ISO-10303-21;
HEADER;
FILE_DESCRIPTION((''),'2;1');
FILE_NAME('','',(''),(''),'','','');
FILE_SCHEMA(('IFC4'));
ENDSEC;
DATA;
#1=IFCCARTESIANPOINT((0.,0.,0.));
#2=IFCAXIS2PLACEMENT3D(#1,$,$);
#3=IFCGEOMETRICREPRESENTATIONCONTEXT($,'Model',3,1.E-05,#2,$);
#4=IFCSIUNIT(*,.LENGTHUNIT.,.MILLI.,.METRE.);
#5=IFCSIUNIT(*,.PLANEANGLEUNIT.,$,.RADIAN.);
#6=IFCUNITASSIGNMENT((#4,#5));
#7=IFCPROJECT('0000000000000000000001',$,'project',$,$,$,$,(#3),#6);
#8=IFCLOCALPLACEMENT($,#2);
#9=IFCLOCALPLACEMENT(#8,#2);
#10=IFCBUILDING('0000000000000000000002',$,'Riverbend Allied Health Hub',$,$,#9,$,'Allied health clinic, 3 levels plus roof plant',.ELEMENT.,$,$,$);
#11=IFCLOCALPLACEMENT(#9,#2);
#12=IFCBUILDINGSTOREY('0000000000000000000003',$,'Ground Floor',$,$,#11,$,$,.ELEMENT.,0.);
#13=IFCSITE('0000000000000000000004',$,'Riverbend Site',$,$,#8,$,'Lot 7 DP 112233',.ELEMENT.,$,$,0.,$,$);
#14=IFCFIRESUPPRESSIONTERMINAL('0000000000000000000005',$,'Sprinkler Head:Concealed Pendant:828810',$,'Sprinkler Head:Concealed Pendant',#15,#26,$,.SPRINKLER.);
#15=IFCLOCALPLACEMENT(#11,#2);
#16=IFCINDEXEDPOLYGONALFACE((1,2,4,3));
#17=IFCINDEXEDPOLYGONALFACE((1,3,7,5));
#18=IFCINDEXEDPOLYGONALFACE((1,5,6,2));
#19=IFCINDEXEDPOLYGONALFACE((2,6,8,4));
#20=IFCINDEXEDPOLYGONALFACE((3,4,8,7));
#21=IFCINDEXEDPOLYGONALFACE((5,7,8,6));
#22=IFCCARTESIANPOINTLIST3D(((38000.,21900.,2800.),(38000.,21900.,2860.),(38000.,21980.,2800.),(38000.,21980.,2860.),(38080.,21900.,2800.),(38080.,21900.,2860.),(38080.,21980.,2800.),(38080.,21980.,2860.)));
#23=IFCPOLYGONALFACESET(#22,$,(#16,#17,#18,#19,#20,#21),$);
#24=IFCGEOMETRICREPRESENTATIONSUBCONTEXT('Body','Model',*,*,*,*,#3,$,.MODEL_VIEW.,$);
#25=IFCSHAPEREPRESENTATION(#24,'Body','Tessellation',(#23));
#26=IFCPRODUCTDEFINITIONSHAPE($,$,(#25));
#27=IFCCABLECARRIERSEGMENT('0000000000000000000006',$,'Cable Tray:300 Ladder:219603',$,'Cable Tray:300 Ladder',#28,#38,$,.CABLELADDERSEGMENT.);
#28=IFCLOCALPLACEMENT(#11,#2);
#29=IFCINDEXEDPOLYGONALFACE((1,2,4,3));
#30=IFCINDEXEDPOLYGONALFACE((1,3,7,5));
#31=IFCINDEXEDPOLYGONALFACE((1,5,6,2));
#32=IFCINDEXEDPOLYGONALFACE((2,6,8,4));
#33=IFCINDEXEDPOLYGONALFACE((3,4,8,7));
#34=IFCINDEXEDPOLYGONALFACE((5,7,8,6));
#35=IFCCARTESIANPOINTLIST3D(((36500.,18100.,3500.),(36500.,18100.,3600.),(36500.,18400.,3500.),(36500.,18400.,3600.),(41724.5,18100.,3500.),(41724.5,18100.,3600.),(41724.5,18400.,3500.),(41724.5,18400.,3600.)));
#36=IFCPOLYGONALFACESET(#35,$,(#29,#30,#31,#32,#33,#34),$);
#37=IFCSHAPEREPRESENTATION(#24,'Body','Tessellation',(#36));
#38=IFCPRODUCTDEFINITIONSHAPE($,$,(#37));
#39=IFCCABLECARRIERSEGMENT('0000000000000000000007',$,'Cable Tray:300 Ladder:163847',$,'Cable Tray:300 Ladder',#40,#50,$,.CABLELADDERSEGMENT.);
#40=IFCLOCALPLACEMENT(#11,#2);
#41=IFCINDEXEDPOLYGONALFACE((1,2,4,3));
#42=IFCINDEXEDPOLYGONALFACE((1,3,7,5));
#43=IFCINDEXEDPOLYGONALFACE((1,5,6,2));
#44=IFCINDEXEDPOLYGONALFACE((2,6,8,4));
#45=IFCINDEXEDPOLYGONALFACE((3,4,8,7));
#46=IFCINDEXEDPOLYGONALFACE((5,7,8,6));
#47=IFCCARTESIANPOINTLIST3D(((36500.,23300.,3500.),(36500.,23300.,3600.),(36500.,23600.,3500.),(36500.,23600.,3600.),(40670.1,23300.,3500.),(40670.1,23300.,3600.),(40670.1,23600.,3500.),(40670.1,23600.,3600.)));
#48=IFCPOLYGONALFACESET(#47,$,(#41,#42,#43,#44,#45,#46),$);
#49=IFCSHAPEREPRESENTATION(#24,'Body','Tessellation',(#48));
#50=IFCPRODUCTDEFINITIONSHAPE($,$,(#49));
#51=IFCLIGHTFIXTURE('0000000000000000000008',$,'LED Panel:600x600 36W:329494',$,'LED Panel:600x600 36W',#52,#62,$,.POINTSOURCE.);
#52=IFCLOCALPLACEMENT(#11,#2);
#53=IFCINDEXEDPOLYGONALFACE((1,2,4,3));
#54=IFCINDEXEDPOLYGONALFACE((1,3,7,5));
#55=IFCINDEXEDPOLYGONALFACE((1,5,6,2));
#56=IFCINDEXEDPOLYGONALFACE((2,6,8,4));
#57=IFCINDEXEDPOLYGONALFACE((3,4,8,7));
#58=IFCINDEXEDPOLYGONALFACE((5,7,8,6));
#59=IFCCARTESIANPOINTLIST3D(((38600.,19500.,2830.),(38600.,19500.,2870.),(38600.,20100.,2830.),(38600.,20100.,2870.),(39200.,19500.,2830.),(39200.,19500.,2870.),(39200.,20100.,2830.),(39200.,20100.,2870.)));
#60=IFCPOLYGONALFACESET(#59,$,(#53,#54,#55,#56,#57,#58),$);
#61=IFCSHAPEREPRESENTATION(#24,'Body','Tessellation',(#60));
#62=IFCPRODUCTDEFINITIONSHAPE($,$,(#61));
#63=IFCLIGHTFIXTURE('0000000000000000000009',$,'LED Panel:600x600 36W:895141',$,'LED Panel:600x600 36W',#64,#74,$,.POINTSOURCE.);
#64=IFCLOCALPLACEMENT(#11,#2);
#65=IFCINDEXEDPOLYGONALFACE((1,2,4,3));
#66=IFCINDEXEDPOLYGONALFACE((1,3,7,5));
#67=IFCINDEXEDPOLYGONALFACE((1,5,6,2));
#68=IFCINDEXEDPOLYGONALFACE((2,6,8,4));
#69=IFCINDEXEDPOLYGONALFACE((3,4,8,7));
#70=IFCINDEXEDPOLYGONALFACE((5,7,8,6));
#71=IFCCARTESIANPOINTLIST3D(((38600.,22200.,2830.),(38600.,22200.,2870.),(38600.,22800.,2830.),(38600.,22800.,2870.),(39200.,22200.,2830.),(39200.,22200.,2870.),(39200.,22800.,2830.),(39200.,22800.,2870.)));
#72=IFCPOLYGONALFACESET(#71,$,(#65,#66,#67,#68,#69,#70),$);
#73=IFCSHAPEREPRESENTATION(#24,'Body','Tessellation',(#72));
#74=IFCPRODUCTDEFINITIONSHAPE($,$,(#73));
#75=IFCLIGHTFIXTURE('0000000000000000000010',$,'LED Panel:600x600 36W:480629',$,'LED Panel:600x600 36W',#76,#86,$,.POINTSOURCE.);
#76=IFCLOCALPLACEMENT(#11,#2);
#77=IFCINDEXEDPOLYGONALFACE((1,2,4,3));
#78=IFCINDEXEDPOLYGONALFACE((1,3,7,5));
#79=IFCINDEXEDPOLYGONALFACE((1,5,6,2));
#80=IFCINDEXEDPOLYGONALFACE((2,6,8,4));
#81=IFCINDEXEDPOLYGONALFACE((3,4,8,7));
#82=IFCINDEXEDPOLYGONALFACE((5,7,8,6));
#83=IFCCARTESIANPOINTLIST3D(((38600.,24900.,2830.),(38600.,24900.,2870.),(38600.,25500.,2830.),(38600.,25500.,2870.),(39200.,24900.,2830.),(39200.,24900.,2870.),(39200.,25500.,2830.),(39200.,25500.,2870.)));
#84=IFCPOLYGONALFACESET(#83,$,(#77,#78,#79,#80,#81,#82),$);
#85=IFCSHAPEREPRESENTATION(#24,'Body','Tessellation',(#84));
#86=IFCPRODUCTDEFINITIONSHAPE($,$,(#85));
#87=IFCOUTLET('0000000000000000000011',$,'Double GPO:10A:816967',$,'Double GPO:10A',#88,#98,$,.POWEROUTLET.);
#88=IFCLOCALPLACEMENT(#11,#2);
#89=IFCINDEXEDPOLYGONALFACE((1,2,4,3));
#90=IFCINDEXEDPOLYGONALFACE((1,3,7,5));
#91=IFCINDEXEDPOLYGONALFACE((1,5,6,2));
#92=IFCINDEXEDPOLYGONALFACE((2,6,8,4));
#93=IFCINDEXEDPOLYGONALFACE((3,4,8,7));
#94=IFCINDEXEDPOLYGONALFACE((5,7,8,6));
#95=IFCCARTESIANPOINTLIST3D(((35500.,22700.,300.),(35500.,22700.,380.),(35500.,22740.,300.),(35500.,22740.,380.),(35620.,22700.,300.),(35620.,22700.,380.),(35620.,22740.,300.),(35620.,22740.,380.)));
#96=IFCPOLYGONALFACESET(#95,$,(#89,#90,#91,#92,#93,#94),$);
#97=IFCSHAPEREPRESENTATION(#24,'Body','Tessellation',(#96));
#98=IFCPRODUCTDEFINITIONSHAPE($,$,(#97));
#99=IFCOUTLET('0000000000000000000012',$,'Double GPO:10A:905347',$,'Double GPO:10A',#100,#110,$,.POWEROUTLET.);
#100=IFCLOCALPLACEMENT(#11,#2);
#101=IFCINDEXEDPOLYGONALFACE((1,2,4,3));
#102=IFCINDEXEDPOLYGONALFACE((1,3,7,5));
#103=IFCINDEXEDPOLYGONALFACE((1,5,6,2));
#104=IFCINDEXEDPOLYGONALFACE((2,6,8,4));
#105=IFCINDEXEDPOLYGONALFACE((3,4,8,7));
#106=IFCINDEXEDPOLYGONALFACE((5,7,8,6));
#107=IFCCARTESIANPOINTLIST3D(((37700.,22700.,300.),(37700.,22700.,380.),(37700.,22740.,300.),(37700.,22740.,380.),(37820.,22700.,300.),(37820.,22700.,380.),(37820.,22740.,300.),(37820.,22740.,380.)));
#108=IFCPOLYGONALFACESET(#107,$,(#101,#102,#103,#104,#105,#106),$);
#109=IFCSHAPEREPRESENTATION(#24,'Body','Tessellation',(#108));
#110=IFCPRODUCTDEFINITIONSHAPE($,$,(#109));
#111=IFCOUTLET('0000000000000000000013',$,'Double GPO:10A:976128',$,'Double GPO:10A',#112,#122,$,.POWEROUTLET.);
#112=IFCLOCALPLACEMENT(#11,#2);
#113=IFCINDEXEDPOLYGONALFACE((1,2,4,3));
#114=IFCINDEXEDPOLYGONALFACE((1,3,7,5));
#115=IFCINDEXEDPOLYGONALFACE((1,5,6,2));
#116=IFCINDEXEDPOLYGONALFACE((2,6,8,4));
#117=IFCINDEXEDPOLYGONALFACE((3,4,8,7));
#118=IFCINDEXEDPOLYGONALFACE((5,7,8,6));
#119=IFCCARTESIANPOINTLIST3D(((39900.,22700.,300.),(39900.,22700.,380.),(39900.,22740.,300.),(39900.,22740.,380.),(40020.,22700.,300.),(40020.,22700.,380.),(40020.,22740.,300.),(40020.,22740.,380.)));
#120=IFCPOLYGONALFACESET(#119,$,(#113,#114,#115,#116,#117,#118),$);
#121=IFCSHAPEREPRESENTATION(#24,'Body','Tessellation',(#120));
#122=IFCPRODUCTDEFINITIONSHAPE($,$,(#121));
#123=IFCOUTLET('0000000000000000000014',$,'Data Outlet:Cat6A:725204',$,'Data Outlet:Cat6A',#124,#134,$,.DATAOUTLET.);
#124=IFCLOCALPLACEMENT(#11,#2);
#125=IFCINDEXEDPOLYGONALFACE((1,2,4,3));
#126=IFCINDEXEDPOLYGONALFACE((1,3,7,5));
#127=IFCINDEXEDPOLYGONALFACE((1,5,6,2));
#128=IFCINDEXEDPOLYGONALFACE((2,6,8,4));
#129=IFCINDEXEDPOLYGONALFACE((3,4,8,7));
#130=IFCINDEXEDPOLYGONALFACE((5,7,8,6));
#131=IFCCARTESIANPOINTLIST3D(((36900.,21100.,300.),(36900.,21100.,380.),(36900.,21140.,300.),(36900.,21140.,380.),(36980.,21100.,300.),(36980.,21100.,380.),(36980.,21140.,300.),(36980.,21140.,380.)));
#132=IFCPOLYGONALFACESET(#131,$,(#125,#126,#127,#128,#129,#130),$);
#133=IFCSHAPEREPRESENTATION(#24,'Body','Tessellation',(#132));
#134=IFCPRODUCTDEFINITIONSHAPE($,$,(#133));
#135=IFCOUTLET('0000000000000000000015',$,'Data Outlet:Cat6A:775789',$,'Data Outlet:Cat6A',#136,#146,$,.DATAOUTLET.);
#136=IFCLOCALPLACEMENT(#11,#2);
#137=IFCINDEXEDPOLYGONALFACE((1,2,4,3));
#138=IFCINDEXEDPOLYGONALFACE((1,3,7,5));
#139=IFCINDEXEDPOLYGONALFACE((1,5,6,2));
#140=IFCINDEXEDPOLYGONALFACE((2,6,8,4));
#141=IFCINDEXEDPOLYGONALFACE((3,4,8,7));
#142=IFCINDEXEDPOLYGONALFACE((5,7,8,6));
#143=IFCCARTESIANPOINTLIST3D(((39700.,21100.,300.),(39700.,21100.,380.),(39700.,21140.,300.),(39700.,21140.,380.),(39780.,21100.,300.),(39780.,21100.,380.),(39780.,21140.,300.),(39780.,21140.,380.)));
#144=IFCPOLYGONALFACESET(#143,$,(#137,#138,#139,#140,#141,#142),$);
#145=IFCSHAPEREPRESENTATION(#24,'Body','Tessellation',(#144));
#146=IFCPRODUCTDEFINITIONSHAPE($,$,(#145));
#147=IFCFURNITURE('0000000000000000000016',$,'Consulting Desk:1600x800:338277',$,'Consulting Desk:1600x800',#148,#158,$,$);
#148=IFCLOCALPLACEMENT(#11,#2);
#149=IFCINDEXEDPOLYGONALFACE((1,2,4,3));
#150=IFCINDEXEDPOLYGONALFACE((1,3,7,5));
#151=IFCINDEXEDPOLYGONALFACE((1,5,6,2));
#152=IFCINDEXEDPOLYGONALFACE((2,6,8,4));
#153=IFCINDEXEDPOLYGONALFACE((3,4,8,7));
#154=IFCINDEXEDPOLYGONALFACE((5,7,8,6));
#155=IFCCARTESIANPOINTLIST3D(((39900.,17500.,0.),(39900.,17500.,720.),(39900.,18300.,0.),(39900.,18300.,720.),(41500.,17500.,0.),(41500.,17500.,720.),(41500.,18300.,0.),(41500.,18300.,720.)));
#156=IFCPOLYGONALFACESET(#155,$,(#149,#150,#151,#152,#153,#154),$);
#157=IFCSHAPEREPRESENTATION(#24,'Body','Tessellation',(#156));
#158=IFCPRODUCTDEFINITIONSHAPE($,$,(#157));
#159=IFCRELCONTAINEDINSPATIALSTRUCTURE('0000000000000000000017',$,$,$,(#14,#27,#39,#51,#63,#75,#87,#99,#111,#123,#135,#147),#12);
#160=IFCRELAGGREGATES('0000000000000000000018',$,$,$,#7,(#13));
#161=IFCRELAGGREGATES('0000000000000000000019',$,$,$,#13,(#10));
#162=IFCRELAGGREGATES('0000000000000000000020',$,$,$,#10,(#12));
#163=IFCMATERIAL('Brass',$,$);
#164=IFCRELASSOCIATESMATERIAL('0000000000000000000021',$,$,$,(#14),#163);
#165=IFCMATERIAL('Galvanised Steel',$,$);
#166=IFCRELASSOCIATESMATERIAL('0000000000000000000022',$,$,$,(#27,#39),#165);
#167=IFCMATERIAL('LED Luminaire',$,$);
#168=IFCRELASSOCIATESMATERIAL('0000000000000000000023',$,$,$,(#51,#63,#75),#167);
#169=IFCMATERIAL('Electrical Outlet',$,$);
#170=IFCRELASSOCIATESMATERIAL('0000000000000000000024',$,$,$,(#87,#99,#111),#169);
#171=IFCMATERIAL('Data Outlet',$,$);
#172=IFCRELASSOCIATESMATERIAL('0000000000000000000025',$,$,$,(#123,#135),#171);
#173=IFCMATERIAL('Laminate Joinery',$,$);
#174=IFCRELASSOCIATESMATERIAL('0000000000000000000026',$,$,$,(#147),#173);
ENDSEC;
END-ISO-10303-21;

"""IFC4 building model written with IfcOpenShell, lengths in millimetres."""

from ifc_helpers import new_model, si_unit, frame, frame_2d, origin, place, context, subcontext, project, spatial, rectangle, extrude, material, element, save


model = new_model("IFC4")

# Units and contexts
model_context = context("Model", 3, precision=1e-05, world=origin())
body_context = subcontext(model_context, "Body", "Model", "MODEL_VIEW")
ifc_project = project(units=[si_unit("LENGTHUNIT", "METRE", prefix="MILLI"), si_unit("PLANEANGLEUNIT", "RADIAN")], contexts=[model_context])

# Site, building, storey
site_placement = place(None, origin())
site = spatial("IfcSite", under=ifc_project, at=site_placement, Name="Riverbend Site", LongName="Lot 7 DP 112233", CompositionType="ELEMENT", RefElevation=0.0)
building_placement = place(site_placement, origin())
building = spatial("IfcBuilding", under=site, at=building_placement, Name="Riverbend Allied Health Hub", LongName="Allied health clinic, 3 levels plus roof plant", CompositionType="ELEMENT")
storey_placement = place(building_placement, origin())
storey = spatial("IfcBuildingStorey", under=building, at=storey_placement, Name="Ground Floor", CompositionType="ELEMENT", Elevation=0.0)

# Shared definitions
ifc_material_1 = material(Name="Galvanised Steel")

# Fire suppression terminal
ifc_material_2 = material(Name="Brass")
fire_suppression_terminal_placement = place(storey_placement, frame((38000.0, 21900.0, 2800.0)))
element("IfcFireSuppressionTerminal", 1, at=fire_suppression_terminal_placement, inside=storey, material=ifc_material_2, Name="Sprinkler Head:Concealed Pendant:828810", ObjectType="Sprinkler Head:Concealed Pendant", PredefinedType="SPRINKLER", context=body_context, shape_type="SweptSolid", body=[
    extrude(rectangle(XDim=80.0, YDim=80.0, at=frame_2d((40.0, 40.0))), origin(), (0.0, 0.0, 1.0), 60.0),
])

# Cable carrier segments
cable_carrier_segment_1_placement = place(storey_placement, frame((36500.0, 18100.0, 3500.0)))
element("IfcCableCarrierSegment", 2, at=cable_carrier_segment_1_placement, inside=storey, material=ifc_material_1, Name="Cable Tray:300 Ladder:219603", ObjectType="Cable Tray:300 Ladder", PredefinedType="CABLELADDERSEGMENT", context=body_context, shape_type="SweptSolid", body=[
    extrude(rectangle(XDim=5224.5, YDim=300.0, at=frame_2d((2612.2, 150.0))), origin(), (0.0, 0.0, 1.0), 100.0),
])
cable_carrier_segment_2_placement = place(storey_placement, frame((36500.0, 23300.0, 3500.0)))
element("IfcCableCarrierSegment", 3, at=cable_carrier_segment_2_placement, inside=storey, material=ifc_material_1, Name="Cable Tray:300 Ladder:163847", ObjectType="Cable Tray:300 Ladder", PredefinedType="CABLELADDERSEGMENT", context=body_context, shape_type="SweptSolid", body=[
    extrude(rectangle(XDim=4170.1, YDim=300.0, at=frame_2d((2085.0, 150.0))), origin(), (0.0, 0.0, 1.0), 100.0),
])

# Light fixtures
ifc_material_3 = material(Name="LED Luminaire")
for number, where, name in (
    (4, (38600.0, 19500.0, 2830.0), "LED Panel:600x600 36W:329494"),
    (5, (38600.0, 22200.0, 2830.0), "LED Panel:600x600 36W:895141"),
    (6, (38600.0, 24900.0, 2830.0), "LED Panel:600x600 36W:480629"),
):
    element("IfcLightFixture", number, at=place(storey_placement, frame(where)), inside=storey, material=ifc_material_3, Name=name, ObjectType="LED Panel:600x600 36W", PredefinedType="POINTSOURCE", context=body_context, shape_type="SweptSolid", body=[
        extrude(rectangle(XDim=600.0, YDim=600.0, at=frame_2d((300.0, 300.0))), origin(), (0.0, 0.0, 1.0), 40.0),
    ])

# Outlets
ifc_material_4 = material(Name="Electrical Outlet")
for number, where, name in (
    (7, (35500.0, 22700.0, 300.0), "Double GPO:10A:816967"),
    (8, (37700.0, 22700.0, 300.0), "Double GPO:10A:905347"),
    (9, (39900.0, 22700.0, 300.0), "Double GPO:10A:976128"),
):
    element("IfcOutlet", number, at=place(storey_placement, frame(where)), inside=storey, material=ifc_material_4, Name=name, ObjectType="Double GPO:10A", PredefinedType="POWEROUTLET", context=body_context, shape_type="SweptSolid", body=[
        extrude(rectangle(XDim=120.0, YDim=40.0, at=frame_2d((60.0, 20.0))), origin(), (0.0, 0.0, 1.0), 80.0),
    ])
ifc_material_5 = material(Name="Data Outlet")
for number, where, name in (
    (10, (36900.0, 21100.0, 300.0), "Data Outlet:Cat6A:725204"),
    (11, (39700.0, 21100.0, 300.0), "Data Outlet:Cat6A:775789"),
):
    element("IfcOutlet", number, at=place(storey_placement, frame(where)), inside=storey, material=ifc_material_5, Name=name, ObjectType="Data Outlet:Cat6A", PredefinedType="DATAOUTLET", context=body_context, shape_type="SweptSolid", body=[
        extrude(rectangle(XDim=80.0, YDim=40.0, at=frame_2d((40.0, 20.0))), origin(), (0.0, 0.0, 1.0), 80.0),
    ])

# Furniture
ifc_material_6 = material(Name="Laminate Joinery")
furniture_placement = place(storey_placement, frame((39900.0, 17500.0, 0.0)))
element("IfcFurniture", 12, at=furniture_placement, inside=storey, material=ifc_material_6, Name="Consulting Desk:1600x800:338277", ObjectType="Consulting Desk:1600x800", context=body_context, shape_type="SweptSolid", body=[
    extrude(rectangle(XDim=1600.0, YDim=800.0, at=frame_2d((800.0, 400.0))), origin(), (0.0, 0.0, 1.0), 720.0),
])

save(model, "model.ifc")
